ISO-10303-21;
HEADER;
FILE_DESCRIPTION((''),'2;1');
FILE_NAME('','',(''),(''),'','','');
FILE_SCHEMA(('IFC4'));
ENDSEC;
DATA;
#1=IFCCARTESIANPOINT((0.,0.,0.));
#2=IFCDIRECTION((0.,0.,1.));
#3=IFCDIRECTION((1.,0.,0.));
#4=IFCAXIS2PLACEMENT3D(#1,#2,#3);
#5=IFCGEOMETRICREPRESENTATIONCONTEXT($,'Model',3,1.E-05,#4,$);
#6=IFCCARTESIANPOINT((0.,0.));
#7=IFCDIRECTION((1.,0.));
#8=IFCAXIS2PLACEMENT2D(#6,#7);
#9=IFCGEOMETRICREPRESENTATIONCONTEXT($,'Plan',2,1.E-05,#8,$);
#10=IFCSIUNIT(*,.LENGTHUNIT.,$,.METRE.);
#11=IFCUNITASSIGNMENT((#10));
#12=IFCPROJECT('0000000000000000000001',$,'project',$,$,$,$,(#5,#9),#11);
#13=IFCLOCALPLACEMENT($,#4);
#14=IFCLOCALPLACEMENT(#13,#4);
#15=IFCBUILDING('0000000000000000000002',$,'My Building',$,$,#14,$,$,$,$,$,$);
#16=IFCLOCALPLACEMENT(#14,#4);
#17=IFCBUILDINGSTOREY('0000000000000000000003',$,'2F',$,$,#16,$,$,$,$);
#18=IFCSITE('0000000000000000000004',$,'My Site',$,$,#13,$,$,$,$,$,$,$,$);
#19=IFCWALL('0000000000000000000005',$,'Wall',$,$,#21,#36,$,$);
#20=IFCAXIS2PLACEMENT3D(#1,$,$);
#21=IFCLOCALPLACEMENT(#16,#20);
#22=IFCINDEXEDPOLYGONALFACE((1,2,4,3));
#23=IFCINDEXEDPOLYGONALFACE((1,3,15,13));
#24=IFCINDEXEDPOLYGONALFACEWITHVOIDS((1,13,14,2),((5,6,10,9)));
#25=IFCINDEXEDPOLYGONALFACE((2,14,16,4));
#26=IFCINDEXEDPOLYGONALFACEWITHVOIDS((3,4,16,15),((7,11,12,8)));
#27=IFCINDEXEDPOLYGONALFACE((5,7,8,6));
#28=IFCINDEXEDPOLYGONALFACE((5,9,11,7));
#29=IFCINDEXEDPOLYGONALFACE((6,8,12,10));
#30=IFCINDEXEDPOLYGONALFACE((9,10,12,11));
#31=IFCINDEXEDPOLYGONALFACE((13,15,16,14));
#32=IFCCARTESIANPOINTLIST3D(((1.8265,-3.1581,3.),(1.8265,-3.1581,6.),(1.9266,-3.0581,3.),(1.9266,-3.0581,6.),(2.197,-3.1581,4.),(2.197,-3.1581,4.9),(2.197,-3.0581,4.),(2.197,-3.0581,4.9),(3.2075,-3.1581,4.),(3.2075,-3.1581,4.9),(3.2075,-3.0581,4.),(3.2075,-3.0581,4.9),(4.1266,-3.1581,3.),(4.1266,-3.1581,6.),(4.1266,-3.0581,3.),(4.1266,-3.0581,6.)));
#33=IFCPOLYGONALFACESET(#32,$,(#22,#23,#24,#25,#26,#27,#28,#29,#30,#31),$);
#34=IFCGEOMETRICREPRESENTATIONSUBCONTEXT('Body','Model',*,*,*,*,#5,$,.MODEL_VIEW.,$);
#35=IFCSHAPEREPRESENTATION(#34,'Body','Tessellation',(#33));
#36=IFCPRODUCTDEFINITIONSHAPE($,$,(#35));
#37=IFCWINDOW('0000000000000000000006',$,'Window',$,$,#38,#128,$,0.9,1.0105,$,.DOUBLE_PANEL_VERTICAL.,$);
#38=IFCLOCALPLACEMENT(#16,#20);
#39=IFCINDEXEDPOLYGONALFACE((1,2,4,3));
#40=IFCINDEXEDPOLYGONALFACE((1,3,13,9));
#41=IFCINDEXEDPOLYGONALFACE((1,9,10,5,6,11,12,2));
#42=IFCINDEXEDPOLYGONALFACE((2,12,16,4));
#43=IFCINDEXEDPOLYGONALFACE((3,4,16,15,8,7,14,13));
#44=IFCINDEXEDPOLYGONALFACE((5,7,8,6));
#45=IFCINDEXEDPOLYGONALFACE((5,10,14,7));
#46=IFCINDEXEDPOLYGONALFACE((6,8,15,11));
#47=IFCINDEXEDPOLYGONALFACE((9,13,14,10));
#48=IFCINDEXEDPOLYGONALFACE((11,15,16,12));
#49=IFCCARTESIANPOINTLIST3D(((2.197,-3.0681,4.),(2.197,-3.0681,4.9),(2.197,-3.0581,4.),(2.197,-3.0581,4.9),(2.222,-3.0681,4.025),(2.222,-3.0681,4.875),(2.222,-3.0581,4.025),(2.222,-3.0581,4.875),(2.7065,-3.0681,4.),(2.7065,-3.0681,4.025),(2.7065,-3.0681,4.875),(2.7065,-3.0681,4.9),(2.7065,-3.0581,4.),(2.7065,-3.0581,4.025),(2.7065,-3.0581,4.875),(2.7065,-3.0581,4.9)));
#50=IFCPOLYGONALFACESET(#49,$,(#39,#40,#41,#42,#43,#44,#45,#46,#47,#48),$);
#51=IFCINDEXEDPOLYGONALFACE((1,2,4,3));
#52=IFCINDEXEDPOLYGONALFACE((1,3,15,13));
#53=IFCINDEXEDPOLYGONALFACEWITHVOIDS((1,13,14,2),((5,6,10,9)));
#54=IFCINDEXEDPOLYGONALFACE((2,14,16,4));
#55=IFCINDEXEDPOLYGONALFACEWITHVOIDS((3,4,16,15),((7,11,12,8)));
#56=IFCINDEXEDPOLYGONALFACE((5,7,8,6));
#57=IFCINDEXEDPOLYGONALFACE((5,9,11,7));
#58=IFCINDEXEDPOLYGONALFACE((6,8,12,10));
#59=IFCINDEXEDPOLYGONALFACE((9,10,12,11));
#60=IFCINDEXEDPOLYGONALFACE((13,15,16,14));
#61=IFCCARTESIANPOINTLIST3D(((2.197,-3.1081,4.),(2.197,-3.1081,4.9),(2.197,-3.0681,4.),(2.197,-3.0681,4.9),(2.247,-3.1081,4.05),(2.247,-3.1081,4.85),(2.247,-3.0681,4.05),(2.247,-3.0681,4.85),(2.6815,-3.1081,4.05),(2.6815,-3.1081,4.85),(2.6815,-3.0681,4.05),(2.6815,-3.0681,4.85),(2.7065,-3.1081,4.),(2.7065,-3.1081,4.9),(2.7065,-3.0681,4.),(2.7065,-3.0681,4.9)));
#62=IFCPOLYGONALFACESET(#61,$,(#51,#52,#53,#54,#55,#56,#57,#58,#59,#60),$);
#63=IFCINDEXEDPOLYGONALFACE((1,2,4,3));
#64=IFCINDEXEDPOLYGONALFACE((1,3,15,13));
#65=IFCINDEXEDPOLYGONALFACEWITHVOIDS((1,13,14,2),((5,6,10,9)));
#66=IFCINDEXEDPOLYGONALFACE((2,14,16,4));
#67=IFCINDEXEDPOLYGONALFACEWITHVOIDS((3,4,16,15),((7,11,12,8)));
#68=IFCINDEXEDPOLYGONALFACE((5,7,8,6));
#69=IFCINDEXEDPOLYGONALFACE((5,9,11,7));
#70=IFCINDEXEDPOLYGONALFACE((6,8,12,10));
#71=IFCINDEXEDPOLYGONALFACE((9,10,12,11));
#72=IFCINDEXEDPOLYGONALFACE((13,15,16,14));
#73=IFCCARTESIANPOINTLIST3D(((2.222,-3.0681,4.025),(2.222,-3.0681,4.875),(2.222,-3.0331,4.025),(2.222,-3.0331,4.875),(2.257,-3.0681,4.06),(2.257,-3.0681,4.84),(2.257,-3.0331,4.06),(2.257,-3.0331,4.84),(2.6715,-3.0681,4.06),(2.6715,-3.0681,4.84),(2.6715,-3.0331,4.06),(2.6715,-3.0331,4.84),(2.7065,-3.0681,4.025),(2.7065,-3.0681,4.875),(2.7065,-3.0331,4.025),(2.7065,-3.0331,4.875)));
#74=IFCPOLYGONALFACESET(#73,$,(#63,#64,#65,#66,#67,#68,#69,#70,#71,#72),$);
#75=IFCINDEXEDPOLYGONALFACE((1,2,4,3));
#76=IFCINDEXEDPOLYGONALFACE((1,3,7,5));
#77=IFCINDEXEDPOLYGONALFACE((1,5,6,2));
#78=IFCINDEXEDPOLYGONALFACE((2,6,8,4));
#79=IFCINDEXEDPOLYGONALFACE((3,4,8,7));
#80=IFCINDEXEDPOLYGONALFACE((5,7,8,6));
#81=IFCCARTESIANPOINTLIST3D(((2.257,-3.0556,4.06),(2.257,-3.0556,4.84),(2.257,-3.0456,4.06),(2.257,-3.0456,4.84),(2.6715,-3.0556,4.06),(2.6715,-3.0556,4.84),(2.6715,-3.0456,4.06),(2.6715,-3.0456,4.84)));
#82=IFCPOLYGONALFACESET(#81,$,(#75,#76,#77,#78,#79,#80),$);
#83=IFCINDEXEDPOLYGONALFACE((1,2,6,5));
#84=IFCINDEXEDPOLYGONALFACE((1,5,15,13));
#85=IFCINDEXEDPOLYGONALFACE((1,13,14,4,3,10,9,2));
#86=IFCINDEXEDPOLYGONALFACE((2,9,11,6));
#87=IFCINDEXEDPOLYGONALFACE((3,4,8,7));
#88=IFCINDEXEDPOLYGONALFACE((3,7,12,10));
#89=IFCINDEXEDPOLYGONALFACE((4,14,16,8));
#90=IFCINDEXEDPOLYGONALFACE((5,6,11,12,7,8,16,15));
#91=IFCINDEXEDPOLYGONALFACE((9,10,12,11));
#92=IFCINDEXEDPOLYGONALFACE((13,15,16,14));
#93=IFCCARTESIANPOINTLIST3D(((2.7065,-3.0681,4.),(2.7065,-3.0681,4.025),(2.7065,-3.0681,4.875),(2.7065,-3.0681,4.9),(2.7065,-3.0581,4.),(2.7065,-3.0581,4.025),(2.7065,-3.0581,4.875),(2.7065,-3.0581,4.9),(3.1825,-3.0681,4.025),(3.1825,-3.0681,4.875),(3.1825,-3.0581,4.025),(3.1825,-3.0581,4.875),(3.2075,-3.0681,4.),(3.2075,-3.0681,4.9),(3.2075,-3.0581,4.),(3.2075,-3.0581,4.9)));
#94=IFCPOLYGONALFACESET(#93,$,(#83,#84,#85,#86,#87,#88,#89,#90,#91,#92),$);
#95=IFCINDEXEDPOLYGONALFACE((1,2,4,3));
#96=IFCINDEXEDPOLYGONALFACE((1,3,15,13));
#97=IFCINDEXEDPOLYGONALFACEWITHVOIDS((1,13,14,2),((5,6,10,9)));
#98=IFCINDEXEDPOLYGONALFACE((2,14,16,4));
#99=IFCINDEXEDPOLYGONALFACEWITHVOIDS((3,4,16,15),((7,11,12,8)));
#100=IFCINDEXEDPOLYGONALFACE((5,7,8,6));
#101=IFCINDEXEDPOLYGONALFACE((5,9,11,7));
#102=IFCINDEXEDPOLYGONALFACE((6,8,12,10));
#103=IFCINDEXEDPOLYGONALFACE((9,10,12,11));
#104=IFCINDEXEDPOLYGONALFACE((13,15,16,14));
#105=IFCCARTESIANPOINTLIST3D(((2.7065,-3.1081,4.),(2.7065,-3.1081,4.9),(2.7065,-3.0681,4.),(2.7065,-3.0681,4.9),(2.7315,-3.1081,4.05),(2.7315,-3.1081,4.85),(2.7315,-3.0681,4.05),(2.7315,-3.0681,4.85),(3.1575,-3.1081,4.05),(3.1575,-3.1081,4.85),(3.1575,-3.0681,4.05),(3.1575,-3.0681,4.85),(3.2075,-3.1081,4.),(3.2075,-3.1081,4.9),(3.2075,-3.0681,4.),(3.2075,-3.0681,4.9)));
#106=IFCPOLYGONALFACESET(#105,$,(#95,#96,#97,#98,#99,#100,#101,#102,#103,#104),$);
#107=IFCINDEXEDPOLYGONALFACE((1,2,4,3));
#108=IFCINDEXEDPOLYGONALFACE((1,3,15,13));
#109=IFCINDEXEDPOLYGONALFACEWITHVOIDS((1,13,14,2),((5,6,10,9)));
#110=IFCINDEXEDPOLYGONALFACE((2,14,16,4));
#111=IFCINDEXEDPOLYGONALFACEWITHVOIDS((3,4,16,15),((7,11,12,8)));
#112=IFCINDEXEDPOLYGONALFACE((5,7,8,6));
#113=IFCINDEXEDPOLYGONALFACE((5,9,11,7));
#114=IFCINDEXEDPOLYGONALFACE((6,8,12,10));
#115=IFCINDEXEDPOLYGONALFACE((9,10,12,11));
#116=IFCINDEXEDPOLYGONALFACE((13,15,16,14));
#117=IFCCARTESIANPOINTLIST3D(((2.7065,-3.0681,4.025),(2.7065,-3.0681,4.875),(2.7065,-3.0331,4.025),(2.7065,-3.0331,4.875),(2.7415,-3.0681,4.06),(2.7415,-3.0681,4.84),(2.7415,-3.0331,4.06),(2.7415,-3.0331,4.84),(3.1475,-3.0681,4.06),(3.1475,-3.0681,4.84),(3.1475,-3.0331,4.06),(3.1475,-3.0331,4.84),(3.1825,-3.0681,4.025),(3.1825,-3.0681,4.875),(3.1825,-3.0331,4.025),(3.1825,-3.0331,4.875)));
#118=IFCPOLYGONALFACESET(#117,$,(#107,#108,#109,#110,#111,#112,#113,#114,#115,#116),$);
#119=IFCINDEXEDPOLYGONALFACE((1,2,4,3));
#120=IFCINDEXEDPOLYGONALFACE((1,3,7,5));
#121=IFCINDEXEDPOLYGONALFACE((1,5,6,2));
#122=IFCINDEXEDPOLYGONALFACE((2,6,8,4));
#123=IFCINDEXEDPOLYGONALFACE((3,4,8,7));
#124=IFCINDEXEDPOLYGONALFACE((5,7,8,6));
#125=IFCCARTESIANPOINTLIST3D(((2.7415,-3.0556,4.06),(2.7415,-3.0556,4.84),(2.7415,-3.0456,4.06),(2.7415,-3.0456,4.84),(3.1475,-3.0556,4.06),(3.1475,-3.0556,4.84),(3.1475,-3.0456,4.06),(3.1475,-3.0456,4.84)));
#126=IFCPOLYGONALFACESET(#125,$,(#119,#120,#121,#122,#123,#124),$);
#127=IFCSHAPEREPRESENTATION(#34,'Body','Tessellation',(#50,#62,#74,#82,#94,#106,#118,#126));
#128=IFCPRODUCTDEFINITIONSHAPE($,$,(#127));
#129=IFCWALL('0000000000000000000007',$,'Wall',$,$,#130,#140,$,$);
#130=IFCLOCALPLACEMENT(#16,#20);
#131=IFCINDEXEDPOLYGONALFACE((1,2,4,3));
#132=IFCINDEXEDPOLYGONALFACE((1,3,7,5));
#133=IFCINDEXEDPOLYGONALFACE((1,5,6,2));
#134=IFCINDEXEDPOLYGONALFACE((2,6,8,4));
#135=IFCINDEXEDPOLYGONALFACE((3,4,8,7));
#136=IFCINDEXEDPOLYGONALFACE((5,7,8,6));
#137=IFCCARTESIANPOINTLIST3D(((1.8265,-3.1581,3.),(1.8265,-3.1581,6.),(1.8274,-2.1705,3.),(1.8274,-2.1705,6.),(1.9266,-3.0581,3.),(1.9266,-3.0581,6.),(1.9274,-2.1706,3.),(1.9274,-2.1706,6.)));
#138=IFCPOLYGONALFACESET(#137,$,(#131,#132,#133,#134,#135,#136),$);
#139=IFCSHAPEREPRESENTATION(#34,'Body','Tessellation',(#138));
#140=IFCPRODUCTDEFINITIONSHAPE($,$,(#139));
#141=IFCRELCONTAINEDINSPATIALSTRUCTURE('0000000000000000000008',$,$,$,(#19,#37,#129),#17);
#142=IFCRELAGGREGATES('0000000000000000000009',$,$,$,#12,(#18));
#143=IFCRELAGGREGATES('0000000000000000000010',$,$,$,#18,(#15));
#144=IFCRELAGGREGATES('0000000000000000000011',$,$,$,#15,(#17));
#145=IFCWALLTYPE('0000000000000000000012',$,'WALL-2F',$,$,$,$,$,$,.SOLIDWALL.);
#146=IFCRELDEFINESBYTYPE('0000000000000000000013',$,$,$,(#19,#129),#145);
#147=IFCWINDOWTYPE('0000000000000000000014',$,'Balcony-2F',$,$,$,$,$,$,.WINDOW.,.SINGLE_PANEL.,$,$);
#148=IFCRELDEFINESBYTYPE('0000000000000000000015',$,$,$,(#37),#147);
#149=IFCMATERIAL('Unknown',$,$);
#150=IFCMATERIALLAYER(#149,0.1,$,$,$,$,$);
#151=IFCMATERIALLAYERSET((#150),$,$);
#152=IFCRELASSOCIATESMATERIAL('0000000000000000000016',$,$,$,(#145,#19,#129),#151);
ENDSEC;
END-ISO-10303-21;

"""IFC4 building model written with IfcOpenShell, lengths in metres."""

from ifc_helpers import new_model, entity, si_unit, frame, origin_with_axes, origin_2d_with_axis, place, context, subcontext, project, spatial, line, indexed_curve, outline, extrude, shape, source, transform, mapped, material, layer, layer_set, layer_usage, type_object, type_shapes, element, fill, save


model = new_model("IFC4")

# Units and contexts
model_context = context("Model", 3, precision=1e-05, world=origin_with_axes())
plan_context = context("Plan", 2, precision=1e-05, world=origin_2d_with_axis())
body_context_1 = subcontext(model_context, "Body", "Model", "MODEL_VIEW")
body_context_2 = subcontext(plan_context, "Body", "Plan", "PLAN_VIEW")
ifc_project = project(units=[si_unit("LENGTHUNIT", "METRE")], contexts=[model_context, plan_context])

# Site, building, storey
site_placement = place(None, origin_with_axes())
site = spatial("IfcSite", under=ifc_project, at=site_placement, Name="My Site")
building_placement = place(site_placement, origin_with_axes())
building = spatial("IfcBuilding", under=site, at=building_placement, Name="My Building")
storey_placement = place(building_placement, origin_with_axes())
storey = spatial("IfcBuildingStorey", under=building, at=storey_placement, Name="2F")

# Shared definitions
ifc_material = material(Name="Unknown")

# Shared definitions
ifc_layer_1 = layer(ifc_material, 0.1)
ifc_layer_set_1 = layer_set([ifc_layer_1])
wall_type_1 = type_object("IfcWallType", Name="WALL-2F", PredefinedType="SOLIDWALL", material=ifc_layer_set_1)

# Wall, opening, window
ifc_layer_usage_1 = layer_usage(ifc_layer_set_1, "AXIS2", "POSITIVE", 0.0)
wall_1_placement = place(storey_placement, frame((4.1266, -3.0581, 3.0), z_axis=(0.0, 0.0, 1.0), x_axis=(-1.0, 0.0, 0.0)))
wall_1 = element("IfcWall", 1, at=wall_1_placement, inside=storey, type_object=wall_type_1, material=ifc_layer_usage_1, Name="Wall", context=body_context_1, shape_type="SweptSolid", body=[
    extrude(outline(indexed_curve([(0.0, 0.0), (0.0, 0.1), (2.3001, 0.1), (2.2, 0.0)], segments=[line(1, 2, 3, 4, 1)])), origin_with_axes(), (0.0, 0.0, 1.0), 3.0),
])
shared_shape_1 = source(origin_with_axes(), body_context_1, "Body", "SweptSolid", [
    extrude(outline(indexed_curve([(0.0, 0.0), (1.0105, 0.0), (1.0105, 0.9), (0.0, 0.9)], segments=[line(1, 2, 3, 4, 1)])), frame((0.0, -0.6, 0.0), z_axis=(0.0, -1.0, 0.0), x_axis=(1.0, 0.0, 0.0)), (0.0, 0.0, -1.0), 1.2),
])
opening_1_placement = place(wall_1_placement, frame((1.9296, 0.1, 1.0), z_axis=(0.0, 0.0, 1.0), x_axis=(-1.0, 0.0, 0.0)))
opening_1 = element("IfcOpeningElement", 2, at=opening_1_placement, cuts=wall_1, PredefinedType="OPENING", context=body_context_1, shape_type="MappedRepresentation", body=[
    mapped(shared_shape_1, transform((0.0, 0.0, 0.0), x_axis=(1.0, 0.0, 0.0), y_axis=(0.0, 1.0, 0.0), z_axis=(0.0, 0.0, 1.0), scale=1.0)),
])
window_type = type_object("IfcWindowType", Name="Balcony-2F", PartitioningType="SINGLE_PANEL", PredefinedType="WINDOW")
shared_shape_2 = source(origin_with_axes(), body_context_1, "Body", "SweptSolid", [
    extrude(outline(indexed_curve([(0.5096, 0.0), (0.0, 0.0), (0.0, 0.9), (0.5096, 0.9), (0.5096, 0.875), (0.025, 0.875), (0.025, 0.025), (0.5096, 0.025)], segments=[line(1, 2, 3, 4, 5, 6, 7, 8, 1)])), frame((0.0, 0.09, 0.0), z_axis=(0.0, -1.0, 0.0), x_axis=(1.0, 0.0, 0.0)), (0.0, 0.0, -1.0), 0.01),
    extrude(outline(indexed_curve([(0.0, 0.0), (0.5096, 0.0), (0.5096, 0.9), (0.0, 0.9)], segments=[line(1, 2, 3, 4, 1)]), holes=[indexed_curve([(0.05, 0.05), (0.4846, 0.05), (0.4846, 0.85), (0.05, 0.85)], segments=[line(1, 2, 3, 4, 1)])]), frame((0.0, 0.05, 0.0), z_axis=(0.0, -1.0, 0.0), x_axis=(1.0, 0.0, 0.0)), (0.0, 0.0, -1.0), 0.04),
    extrude(outline(indexed_curve([(0.0, 0.0), (0.4846, 0.0), (0.4846, 0.85), (0.0, 0.85)], segments=[line(1, 2, 3, 4, 1)]), holes=[indexed_curve([(0.035, 0.035), (0.4496, 0.035), (0.4496, 0.815), (0.035, 0.815)], segments=[line(1, 2, 3, 4, 1)])]), frame((0.025, 0.09, 0.025), z_axis=(0.0, -1.0, 0.0), x_axis=(1.0, 0.0, 0.0)), (0.0, 0.0, -1.0), 0.035),
    extrude(outline(indexed_curve([(0.035, 0.035), (0.4496, 0.035), (0.4496, 0.815), (0.035, 0.815)], segments=[line(1, 2, 3, 4, 1)])), frame((0.025, 0.1025, 0.025), z_axis=(0.0, -1.0, 0.0), x_axis=(1.0, 0.0, 0.0)), (0.0, 0.0, -1.0), 0.01),
    extrude(outline(indexed_curve([(0.0, 0.9), (0.501, 0.9), (0.501, 0.0), (0.0, 0.0), (0.0, 0.025), (0.476, 0.025), (0.476, 0.875), (0.0, 0.875)], segments=[line(1, 2, 3, 4, 5, 6, 7, 8, 1)])), frame((0.5096, 0.09, 0.0), z_axis=(0.0, -1.0, 0.0), x_axis=(1.0, 0.0, 0.0)), (0.0, 0.0, -1.0), 0.01),
    extrude(outline(indexed_curve([(0.0, 0.0), (0.501, 0.0), (0.501, 0.9), (0.0, 0.9)], segments=[line(1, 2, 3, 4, 1)]), holes=[indexed_curve([(0.025, 0.05), (0.451, 0.05), (0.451, 0.85), (0.025, 0.85)], segments=[line(1, 2, 3, 4, 1)])]), frame((0.5096, 0.05, 0.0), z_axis=(0.0, -1.0, 0.0), x_axis=(1.0, 0.0, 0.0)), (0.0, 0.0, -1.0), 0.04),
    extrude(outline(indexed_curve([(0.0, 0.0), (0.476, 0.0), (0.476, 0.85), (0.0, 0.85)], segments=[line(1, 2, 3, 4, 1)]), holes=[indexed_curve([(0.035, 0.035), (0.441, 0.035), (0.441, 0.815), (0.035, 0.815)], segments=[line(1, 2, 3, 4, 1)])]), frame((0.5096, 0.09, 0.025), z_axis=(0.0, -1.0, 0.0), x_axis=(1.0, 0.0, 0.0)), (0.0, 0.0, -1.0), 0.035),
    extrude(outline(indexed_curve([(0.035, 0.035), (0.441, 0.035), (0.441, 0.815), (0.035, 0.815)], segments=[line(1, 2, 3, 4, 1)])), frame((0.5096, 0.1025, 0.025), z_axis=(0.0, -1.0, 0.0), x_axis=(1.0, 0.0, 0.0)), (0.0, 0.0, -1.0), 0.01),
])
shared_shape_3 = source(origin_with_axes(), body_context_2, "Body", "Curve2D", [
    entity("IfcIndexedPolyCurve", entity("IfcCartesianPointList2D", [[0.05, 0.05], [0.4846, 0.05]])),
    entity("IfcIndexedPolyCurve", entity("IfcCartesianPointList2D", [[0.0, 0.1], [0.025, 0.1], [0.025, 0.09], [0.05, 0.09], [0.05, 0.05], [0.0, 0.05]]), [entity("IfcLineIndex", [1, 2, 3, 4, 5, 6, 1])]),
    entity("IfcIndexedPolyCurve", entity("IfcCartesianPointList2D", [[0.5096, 0.1], [0.5096, 0.1], [0.5096, 0.09], [0.4846, 0.09], [0.4846, 0.05], [0.5096, 0.05]])),
    entity("IfcIndexedPolyCurve", entity("IfcCartesianPointList2D", [[0.025, 0.09], [0.06, 0.09], [0.06, 0.125], [0.025, 0.125]]), [entity("IfcLineIndex", [1, 2, 3, 4, 1])]),
    entity("IfcIndexedPolyCurve", entity("IfcCartesianPointList2D", [[0.5096, 0.09], [0.4746, 0.09], [0.4746, 0.125], [0.5096, 0.125]]), [entity("IfcLineIndex", [1, 2, 3, 4, 1])]),
    entity("IfcIndexedPolyCurve", entity("IfcCartesianPointList2D", [[0.06, 0.09], [0.4746, 0.09]])),
    entity("IfcIndexedPolyCurve", entity("IfcCartesianPointList2D", [[0.06, 0.125], [0.4746, 0.125]])),
    entity("IfcIndexedPolyCurve", entity("IfcCartesianPointList2D", [[0.06, 0.1075], [0.4746, 0.1075]])),
    entity("IfcIndexedPolyCurve", entity("IfcCartesianPointList2D", [[0.5346, 0.05], [0.9605, 0.05]])),
    entity("IfcIndexedPolyCurve", entity("IfcCartesianPointList2D", [[0.5096, 0.1], [0.5096, 0.1], [0.5096, 0.09], [0.5346, 0.09], [0.5346, 0.05], [0.5096, 0.05]])),
    entity("IfcIndexedPolyCurve", entity("IfcCartesianPointList2D", [[1.0105, 0.1], [0.9855, 0.1], [0.9855, 0.09], [0.9605, 0.09], [0.9605, 0.05], [1.0105, 0.05]]), [entity("IfcLineIndex", [1, 2, 3, 4, 5, 6, 1])]),
    entity("IfcIndexedPolyCurve", entity("IfcCartesianPointList2D", [[0.5096, 0.09], [0.5446, 0.09], [0.5446, 0.125], [0.5096, 0.125]]), [entity("IfcLineIndex", [1, 2, 3, 4, 1])]),
    entity("IfcIndexedPolyCurve", entity("IfcCartesianPointList2D", [[0.9855, 0.09], [0.9505, 0.09], [0.9505, 0.125], [0.9855, 0.125]]), [entity("IfcLineIndex", [1, 2, 3, 4, 1])]),
    entity("IfcIndexedPolyCurve", entity("IfcCartesianPointList2D", [[0.5446, 0.09], [0.9505, 0.09]])),
    entity("IfcIndexedPolyCurve", entity("IfcCartesianPointList2D", [[0.5446, 0.125], [0.9505, 0.125]])),
    entity("IfcIndexedPolyCurve", entity("IfcCartesianPointList2D", [[0.5446, 0.1075], [0.9505, 0.1075]])),
])
type_shapes(window_type, [shared_shape_2, shared_shape_3])
window_placement = place(opening_1_placement, frame((0.0, 0.0, 0.0), z_axis=(0.0, 0.0, 1.0), x_axis=(1.0, 0.0, 0.0)))
window = element("IfcWindow", 3, at=window_placement, inside=storey, type_object=window_type, Name="Window", OverallHeight=0.9, OverallWidth=1.0105, PartitioningType="DOUBLE_PANEL_VERTICAL", shapes=[
    shape(body_context_1, "Body", "MappedRepresentation", [mapped(shared_shape_2, transform((0.0, 0.0, 0.0), x_axis=(1.0, 0.0, 0.0), y_axis=(0.0, 1.0, 0.0), z_axis=(0.0, 0.0, 1.0), scale=1.0))]),
    shape(body_context_2, "Body", "MappedRepresentation", [mapped(shared_shape_3, transform((0.0, 0.0, 0.0), x_axis=(1.0, 0.0, 0.0), y_axis=(0.0, 1.0, 0.0), z_axis=(0.0, 0.0, 1.0), scale=1.0))]),
])
fill(opening_1, window)

# Wall
ifc_layer_usage_2 = layer_usage(ifc_layer_set_1, "AXIS2", "POSITIVE", 0.0)
wall_2_placement = place(storey_placement, frame((1.9266, -3.0581, 3.0), z_axis=(0.0, 0.0, 1.0), x_axis=(0.000947, 1.0, 0.0)))
element("IfcWall", 4, at=wall_2_placement, inside=storey, type_object=wall_type_1, material=ifc_layer_usage_2, Name="Wall", context=body_context_1, shape_type="SweptSolid", body=[
    extrude(outline(indexed_curve([(0.0, 0.0), (-0.1001, 0.1), (0.8875, 0.1), (0.8875, 0.0)], segments=[line(1, 2, 3, 4, 1)])), origin_with_axes(), (0.0, 0.0, 1.0), 3.0),
])

save(model, "model.ifc")
